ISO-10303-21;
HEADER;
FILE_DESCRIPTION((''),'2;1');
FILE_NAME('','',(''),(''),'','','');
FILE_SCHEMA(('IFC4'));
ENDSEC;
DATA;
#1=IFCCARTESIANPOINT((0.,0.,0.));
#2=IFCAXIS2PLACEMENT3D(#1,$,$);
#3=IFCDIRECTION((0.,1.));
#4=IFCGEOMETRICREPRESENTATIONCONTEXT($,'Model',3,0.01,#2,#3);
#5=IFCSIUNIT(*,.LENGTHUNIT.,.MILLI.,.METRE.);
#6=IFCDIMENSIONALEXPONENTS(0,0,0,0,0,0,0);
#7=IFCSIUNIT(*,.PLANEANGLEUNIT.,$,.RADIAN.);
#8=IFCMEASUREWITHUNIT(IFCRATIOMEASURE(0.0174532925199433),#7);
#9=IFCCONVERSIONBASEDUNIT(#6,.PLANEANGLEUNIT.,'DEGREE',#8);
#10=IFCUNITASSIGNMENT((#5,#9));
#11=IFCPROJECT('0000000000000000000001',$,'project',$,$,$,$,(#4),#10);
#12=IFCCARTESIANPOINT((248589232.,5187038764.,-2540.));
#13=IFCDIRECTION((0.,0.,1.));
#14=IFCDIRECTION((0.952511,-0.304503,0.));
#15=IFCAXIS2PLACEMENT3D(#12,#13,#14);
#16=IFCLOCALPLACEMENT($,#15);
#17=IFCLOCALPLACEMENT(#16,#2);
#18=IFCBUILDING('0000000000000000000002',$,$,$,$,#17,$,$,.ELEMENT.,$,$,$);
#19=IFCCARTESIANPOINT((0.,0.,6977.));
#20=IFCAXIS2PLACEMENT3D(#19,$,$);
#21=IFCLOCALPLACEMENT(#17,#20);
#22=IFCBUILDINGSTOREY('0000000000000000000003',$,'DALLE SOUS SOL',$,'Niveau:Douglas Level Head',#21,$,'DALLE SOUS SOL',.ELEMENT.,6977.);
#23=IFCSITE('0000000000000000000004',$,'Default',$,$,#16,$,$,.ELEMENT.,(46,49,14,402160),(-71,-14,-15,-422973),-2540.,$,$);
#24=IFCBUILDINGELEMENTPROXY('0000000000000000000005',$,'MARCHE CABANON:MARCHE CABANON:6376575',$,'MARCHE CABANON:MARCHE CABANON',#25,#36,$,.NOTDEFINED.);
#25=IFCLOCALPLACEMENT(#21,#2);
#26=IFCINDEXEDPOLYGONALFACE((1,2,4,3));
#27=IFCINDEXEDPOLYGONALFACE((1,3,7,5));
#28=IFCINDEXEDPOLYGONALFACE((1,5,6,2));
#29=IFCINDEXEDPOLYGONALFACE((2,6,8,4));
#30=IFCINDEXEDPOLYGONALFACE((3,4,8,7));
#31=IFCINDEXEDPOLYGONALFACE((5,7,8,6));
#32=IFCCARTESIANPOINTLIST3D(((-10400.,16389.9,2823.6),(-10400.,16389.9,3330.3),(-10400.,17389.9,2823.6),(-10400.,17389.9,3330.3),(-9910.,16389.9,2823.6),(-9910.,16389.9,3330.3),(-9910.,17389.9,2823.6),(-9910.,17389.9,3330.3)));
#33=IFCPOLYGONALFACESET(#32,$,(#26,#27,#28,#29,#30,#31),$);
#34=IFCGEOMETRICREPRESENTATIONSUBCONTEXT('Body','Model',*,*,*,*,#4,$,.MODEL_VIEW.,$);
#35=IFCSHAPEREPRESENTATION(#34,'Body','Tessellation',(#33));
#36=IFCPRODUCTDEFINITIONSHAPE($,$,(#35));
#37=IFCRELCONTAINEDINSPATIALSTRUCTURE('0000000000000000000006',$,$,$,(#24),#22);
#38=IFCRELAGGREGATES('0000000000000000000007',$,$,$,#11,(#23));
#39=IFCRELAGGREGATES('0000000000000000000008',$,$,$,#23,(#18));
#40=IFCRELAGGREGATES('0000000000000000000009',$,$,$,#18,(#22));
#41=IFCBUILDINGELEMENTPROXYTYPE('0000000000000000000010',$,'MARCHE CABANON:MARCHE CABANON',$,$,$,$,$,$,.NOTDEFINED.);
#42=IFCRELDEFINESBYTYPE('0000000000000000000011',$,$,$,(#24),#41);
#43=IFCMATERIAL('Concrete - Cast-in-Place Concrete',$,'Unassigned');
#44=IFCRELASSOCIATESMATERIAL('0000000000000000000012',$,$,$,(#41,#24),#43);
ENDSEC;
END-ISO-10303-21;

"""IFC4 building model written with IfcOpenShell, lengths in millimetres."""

from ifc_helpers import new_model, entity, si_unit, converted_unit, direction, frame, origin, place, context, subcontext, project, spatial, indexed_curve, outline, extrude, source, transform, mapped, material, type_object, type_shapes, element, save


model = new_model("IFC4")

# Units and contexts
model_context = context("Model", 3, precision=0.01, world=origin(), true_north=direction((0.0, 1.0)))
body_context = subcontext(model_context, "Body", "Model", "MODEL_VIEW")
ifc_project = project(units=[si_unit("LENGTHUNIT", "METRE", prefix="MILLI"), converted_unit("PLANEANGLEUNIT", "DEGREE", entity("IfcRatioMeasure", 0.0174532925199433), si_unit("PLANEANGLEUNIT", "RADIAN"), dimensions=[0, 0, 0, 0, 0, 0, 0])], contexts=[model_context])

# Site, building, storey
site_placement = place(None, frame((248589232.0, 5187038764.0, -2540.0), z_axis=(0.0, 0.0, 1.0), x_axis=(0.952511, -0.304503, 0.0)))
site = spatial("IfcSite", under=ifc_project, at=site_placement, Name="Default", CompositionType="ELEMENT", RefLatitude=(46, 49, 14, 402160), RefLongitude=(-71, -14, -15, -422973), RefElevation=-2540.0)
building_placement = place(site_placement, origin())
building = spatial("IfcBuilding", under=site, at=building_placement, CompositionType="ELEMENT")
storey_placement = place(building_placement, frame((0.0, 0.0, 6977.0)))
storey = spatial("IfcBuildingStorey", under=building, at=storey_placement, Name="DALLE SOUS SOL", ObjectType="Niveau:Douglas Level Head", LongName="DALLE SOUS SOL", CompositionType="ELEMENT", Elevation=6977.0)

# Building element proxy
ifc_material = material(Name="Concrete - Cast-in-Place Concrete", Category="Unassigned")
building_element_proxy_type = type_object("IfcBuildingElementProxyType", Name="MARCHE CABANON:MARCHE CABANON", PredefinedType="NOTDEFINED", material=ifc_material)
shared_shape = source(origin(), body_context, "Body", "SweptSolid", [
    extrude(outline(indexed_curve([(-245.0, -500.0), (245.0, -500.0), (245.0, 500.0), (-245.0, 500.0), (-245.0, -500.0)], self_intersect=False)), frame((-10155.0, 16889.9, 9800.6), z_axis=(0.0, 0.0, 1.0), x_axis=(-1.0, 0.0, 0.0)), (0.0, 0.0, 1.0), 506.8),
])
type_shapes(building_element_proxy_type, [shared_shape])
proxy_placement = place(storey_placement, frame((0.0, 0.0, -6977.0)))
element("IfcBuildingElementProxy", 1, at=proxy_placement, inside=storey, type_object=building_element_proxy_type, material=ifc_material, Name="MARCHE CABANON:MARCHE CABANON:6376575", ObjectType="MARCHE CABANON:MARCHE CABANON", PredefinedType="NOTDEFINED", context=body_context, shape_type="MappedRepresentation", body=[
    mapped(shared_shape, transform((0.0, 0.0, 0.0), scale=1.0)),
])

save(model, "model.ifc")
